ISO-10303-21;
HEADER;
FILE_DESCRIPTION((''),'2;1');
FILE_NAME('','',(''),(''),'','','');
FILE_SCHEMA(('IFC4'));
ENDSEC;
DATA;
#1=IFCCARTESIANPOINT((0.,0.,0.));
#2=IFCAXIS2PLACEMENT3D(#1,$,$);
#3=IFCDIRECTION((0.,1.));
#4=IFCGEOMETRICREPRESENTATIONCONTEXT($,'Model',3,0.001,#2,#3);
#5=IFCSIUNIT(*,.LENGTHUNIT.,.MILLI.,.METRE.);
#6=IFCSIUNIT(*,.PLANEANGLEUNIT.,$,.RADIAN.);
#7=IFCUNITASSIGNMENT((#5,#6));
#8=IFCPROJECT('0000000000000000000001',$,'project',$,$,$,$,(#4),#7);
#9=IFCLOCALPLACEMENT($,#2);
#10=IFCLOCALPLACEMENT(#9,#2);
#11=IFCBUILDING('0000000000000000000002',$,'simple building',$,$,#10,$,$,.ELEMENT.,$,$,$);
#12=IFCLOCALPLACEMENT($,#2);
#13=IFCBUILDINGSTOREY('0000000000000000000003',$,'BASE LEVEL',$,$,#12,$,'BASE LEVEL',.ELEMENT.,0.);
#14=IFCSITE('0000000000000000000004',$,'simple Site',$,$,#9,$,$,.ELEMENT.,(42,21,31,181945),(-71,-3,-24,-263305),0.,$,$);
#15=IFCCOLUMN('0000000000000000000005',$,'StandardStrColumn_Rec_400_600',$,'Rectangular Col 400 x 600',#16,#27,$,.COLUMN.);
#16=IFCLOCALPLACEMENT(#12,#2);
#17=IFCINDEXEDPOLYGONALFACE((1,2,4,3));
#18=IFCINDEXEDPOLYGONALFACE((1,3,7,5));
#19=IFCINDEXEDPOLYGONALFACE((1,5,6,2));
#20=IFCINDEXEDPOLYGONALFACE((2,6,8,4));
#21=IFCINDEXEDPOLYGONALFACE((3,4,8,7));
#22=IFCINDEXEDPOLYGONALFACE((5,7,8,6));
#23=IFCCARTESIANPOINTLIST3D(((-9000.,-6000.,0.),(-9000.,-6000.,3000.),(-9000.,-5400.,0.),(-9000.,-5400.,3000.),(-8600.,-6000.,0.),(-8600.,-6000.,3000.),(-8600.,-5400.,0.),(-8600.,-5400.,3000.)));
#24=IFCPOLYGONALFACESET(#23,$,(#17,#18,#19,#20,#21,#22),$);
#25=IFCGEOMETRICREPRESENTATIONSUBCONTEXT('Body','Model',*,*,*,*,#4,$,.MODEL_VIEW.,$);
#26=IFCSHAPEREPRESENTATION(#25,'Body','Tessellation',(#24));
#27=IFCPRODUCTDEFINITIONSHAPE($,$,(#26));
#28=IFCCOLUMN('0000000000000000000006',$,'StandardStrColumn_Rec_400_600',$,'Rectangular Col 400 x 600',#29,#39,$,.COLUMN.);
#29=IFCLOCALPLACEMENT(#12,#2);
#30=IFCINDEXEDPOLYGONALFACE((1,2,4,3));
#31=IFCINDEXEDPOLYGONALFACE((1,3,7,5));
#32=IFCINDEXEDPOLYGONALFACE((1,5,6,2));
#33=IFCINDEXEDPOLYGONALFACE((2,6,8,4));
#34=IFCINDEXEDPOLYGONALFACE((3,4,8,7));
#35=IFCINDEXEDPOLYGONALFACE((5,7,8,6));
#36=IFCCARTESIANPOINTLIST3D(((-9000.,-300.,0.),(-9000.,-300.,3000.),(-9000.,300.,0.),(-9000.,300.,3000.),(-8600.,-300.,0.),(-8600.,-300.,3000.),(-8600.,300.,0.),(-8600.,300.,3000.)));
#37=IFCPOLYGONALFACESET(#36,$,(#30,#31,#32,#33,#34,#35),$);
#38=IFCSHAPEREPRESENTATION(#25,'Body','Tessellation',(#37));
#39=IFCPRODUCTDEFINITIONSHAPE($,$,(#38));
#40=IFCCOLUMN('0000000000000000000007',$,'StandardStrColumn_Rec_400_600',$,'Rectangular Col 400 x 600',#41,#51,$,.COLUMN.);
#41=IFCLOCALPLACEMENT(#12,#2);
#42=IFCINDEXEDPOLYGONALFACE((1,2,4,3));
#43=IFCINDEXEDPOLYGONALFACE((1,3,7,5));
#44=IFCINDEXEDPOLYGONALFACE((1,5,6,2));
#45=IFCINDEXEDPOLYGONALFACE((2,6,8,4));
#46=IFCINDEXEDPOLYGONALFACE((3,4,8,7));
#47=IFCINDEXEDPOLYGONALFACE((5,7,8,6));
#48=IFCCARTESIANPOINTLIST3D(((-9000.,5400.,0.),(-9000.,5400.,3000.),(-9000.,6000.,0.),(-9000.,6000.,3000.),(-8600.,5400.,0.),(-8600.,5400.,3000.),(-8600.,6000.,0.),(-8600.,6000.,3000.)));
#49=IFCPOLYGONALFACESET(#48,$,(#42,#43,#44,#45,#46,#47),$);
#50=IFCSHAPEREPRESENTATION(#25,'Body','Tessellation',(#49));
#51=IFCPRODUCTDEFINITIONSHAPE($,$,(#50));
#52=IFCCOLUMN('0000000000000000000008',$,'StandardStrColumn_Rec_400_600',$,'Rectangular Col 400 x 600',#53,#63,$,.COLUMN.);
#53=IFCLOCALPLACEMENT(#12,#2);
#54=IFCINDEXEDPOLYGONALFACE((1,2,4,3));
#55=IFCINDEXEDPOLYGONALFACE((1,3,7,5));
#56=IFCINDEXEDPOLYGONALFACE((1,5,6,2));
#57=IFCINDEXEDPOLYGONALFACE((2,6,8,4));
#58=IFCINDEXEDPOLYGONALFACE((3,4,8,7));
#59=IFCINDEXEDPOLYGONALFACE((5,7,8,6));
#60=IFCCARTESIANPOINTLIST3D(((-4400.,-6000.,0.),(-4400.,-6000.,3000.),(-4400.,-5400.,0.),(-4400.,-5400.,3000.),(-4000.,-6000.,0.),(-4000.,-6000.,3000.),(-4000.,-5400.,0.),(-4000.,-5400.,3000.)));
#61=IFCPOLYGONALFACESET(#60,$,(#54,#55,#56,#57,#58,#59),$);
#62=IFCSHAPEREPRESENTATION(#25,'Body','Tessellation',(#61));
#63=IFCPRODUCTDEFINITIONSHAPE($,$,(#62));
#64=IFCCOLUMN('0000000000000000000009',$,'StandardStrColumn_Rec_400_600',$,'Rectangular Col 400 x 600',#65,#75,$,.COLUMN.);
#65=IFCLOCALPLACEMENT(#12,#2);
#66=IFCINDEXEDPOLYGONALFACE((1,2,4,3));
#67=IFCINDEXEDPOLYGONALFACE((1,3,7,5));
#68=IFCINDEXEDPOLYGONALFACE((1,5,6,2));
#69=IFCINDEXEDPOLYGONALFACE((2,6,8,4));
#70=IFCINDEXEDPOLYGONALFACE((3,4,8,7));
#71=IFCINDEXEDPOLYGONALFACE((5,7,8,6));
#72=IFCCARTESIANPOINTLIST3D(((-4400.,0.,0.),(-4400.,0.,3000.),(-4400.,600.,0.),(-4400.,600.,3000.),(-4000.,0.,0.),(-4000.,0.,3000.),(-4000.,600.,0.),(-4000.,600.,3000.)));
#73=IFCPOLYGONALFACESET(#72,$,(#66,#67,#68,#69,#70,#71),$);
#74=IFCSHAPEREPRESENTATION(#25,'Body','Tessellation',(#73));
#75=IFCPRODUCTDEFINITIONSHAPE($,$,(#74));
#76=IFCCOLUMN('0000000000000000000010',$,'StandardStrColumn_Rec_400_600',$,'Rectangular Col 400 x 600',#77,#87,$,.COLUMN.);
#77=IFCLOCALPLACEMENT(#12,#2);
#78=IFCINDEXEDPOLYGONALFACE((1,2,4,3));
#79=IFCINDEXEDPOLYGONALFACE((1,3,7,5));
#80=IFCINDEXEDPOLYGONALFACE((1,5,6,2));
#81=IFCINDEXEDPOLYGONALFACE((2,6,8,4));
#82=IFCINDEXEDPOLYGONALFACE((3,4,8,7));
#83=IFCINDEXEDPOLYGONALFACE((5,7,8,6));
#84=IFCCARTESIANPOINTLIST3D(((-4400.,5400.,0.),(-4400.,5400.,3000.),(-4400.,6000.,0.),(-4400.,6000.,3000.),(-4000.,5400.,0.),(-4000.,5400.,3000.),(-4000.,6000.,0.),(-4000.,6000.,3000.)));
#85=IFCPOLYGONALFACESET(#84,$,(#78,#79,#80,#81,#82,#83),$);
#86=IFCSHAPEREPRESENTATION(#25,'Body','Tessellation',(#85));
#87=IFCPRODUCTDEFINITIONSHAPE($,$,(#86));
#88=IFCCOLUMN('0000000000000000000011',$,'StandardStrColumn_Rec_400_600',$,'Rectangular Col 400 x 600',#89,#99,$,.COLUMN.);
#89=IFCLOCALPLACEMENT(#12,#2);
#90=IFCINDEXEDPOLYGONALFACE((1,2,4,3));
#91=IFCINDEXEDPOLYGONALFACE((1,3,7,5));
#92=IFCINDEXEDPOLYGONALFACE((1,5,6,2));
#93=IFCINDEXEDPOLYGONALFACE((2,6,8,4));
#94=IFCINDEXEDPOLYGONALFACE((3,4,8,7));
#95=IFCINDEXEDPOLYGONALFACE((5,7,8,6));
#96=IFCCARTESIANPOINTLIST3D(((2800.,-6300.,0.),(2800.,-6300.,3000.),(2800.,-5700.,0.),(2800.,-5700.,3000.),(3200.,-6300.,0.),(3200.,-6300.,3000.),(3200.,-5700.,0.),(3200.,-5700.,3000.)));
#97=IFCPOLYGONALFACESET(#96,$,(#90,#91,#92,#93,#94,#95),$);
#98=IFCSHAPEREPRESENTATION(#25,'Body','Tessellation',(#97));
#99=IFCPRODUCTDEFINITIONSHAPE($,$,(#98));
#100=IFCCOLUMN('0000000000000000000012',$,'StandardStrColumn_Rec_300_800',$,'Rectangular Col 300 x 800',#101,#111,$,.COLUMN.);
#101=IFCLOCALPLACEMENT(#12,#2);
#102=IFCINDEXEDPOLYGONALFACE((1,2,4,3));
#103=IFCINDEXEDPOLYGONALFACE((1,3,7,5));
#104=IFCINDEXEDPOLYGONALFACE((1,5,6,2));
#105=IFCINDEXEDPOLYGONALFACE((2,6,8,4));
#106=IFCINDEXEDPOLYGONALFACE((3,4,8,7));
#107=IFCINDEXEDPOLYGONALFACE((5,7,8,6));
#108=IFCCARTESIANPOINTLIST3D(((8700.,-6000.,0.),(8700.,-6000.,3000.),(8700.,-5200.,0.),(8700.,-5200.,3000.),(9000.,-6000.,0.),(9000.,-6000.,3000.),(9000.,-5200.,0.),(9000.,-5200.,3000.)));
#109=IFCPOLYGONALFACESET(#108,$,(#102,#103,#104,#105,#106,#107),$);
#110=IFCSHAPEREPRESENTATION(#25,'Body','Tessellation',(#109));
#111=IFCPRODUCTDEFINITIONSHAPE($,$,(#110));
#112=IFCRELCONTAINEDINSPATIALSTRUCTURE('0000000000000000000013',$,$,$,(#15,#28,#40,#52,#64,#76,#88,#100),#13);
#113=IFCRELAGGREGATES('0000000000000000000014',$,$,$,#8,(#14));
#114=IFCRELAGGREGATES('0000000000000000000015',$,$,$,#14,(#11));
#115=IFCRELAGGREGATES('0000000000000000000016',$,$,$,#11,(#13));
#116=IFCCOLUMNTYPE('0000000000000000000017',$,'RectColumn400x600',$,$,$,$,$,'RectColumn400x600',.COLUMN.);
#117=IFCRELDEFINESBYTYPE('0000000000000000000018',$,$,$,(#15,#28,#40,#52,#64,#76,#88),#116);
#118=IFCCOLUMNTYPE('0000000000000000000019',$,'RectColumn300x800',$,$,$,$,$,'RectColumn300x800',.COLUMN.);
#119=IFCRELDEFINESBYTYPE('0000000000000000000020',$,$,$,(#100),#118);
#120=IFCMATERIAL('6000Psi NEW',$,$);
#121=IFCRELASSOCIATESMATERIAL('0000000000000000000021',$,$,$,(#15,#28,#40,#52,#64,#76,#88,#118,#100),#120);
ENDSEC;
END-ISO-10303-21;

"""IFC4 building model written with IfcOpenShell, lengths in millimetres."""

from ifc_helpers import new_model, si_unit, direction, frame, origin, origin_with_axes, origin_2d_with_axis, place, context, subcontext, project, spatial, rectangle, extrude, material, material_profile, profile_set, profile_usage, type_object, element, save


model = new_model("IFC4")

# Units and contexts
model_context = context("Model", 3, precision=0.001, world=origin(), true_north=direction((0.0, 1.0)))
body_context = subcontext(model_context, "Body", "Model", "MODEL_VIEW")
ifc_project = project(units=[si_unit("LENGTHUNIT", "METRE", prefix="MILLI"), si_unit("PLANEANGLEUNIT", "RADIAN")], contexts=[model_context])

# Site, building, storey
site_placement = place(None, origin())
site = spatial("IfcSite", under=ifc_project, at=site_placement, Name="simple Site", CompositionType="ELEMENT", RefLatitude=(42, 21, 31, 181945), RefLongitude=(-71, -3, -24, -263305), RefElevation=0.0)
building_placement = place(site_placement, origin())
building = spatial("IfcBuilding", under=site, at=building_placement, Name="simple building", CompositionType="ELEMENT")
storey_placement = place(None, origin())
storey = spatial("IfcBuildingStorey", under=building, at=storey_placement, Name="BASE LEVEL", LongName="BASE LEVEL", CompositionType="ELEMENT", Elevation=0.0)

# Columns
ifc_material = material(Name="6000Psi NEW")
ifc_material_profile_1 = material_profile(ifc_material, rectangle(XDim=400.0, YDim=600.0, at=origin_2d_with_axis()))
ifc_profile_set_1 = profile_set([ifc_material_profile_1])
ifc_profile_usage_1 = profile_usage(ifc_profile_set_1, cardinal=7)
column_type_1 = type_object("IfcColumnType", Name="RectColumn400x600", ElementType="RectColumn400x600", PredefinedType="COLUMN")
column_1_placement = place(None, frame((-8800.0, -5700.0, 0.0), z_axis=(0.0, 0.0, 1.0), x_axis=(1.0, 0.0, 0.0)))
element("IfcColumn", 1, at=column_1_placement, inside=storey, type_object=column_type_1, material=ifc_profile_usage_1, Name="StandardStrColumn_Rec_400_600", ObjectType="Rectangular Col 400 x 600", PredefinedType="COLUMN", context=body_context, shape_type="SweptSolid", body=[
    extrude(rectangle(XDim=400.0, YDim=600.0, at=origin_2d_with_axis()), origin_with_axes(), (0.0, 0.0, 1.0), 3000.0),
])
ifc_profile_usage_2 = profile_usage(ifc_profile_set_1, cardinal=4)
column_2_placement = place(None, frame((-8800.0, 0.0, 0.0), z_axis=(0.0, 0.0, 1.0), x_axis=(1.0, 0.0, 0.0)))
element("IfcColumn", 2, at=column_2_placement, inside=storey, type_object=column_type_1, material=ifc_profile_usage_2, Name="StandardStrColumn_Rec_400_600", ObjectType="Rectangular Col 400 x 600", PredefinedType="COLUMN", context=body_context, shape_type="SweptSolid", body=[
    extrude(rectangle(XDim=400.0, YDim=600.0, at=origin_2d_with_axis()), origin_with_axes(), (0.0, 0.0, 1.0), 3000.0),
])
ifc_profile_usage_3 = profile_usage(ifc_profile_set_1, cardinal=1)
column_3_placement = place(None, frame((-8800.0, 5700.0, 0.0), z_axis=(0.0, 0.0, 1.0), x_axis=(1.0, 0.0, 0.0)))
element("IfcColumn", 3, at=column_3_placement, inside=storey, type_object=column_type_1, material=ifc_profile_usage_3, Name="StandardStrColumn_Rec_400_600", ObjectType="Rectangular Col 400 x 600", PredefinedType="COLUMN", context=body_context, shape_type="SweptSolid", body=[
    extrude(rectangle(XDim=400.0, YDim=600.0, at=origin_2d_with_axis()), origin_with_axes(), (0.0, 0.0, 1.0), 3000.0),
])
ifc_profile_usage_4 = profile_usage(ifc_profile_set_1, cardinal=9)
for number, where, z_axis, x_axis, name in (
    (4, (-4200.0, -5700.0, 0.0), (0.0, 0.0, 1.0), (1.0, 0.0, 0.0), "StandardStrColumn_Rec_400_600"),
    (5, (-4200.0, 300.0, 0.0), (0.0, 0.0, 1.0), (1.0, 0.0, 0.0), "StandardStrColumn_Rec_400_600"),
):
    element("IfcColumn", number, at=place(None, frame(where, z_axis=z_axis, x_axis=x_axis)), inside=storey, type_object=column_type_1, material=ifc_profile_usage_4, Name=name, ObjectType="Rectangular Col 400 x 600", PredefinedType="COLUMN", context=body_context, shape_type="SweptSolid", body=[
        extrude(rectangle(XDim=400.0, YDim=600.0, at=origin_2d_with_axis()), origin_with_axes(), (0.0, 0.0, 1.0), 3000.0),
    ])
ifc_profile_usage_5 = profile_usage(ifc_profile_set_1, cardinal=3)
column_4_placement = place(None, frame((-4200.0, 5700.0, 0.0), z_axis=(0.0, 0.0, 1.0), x_axis=(1.0, 0.0, 0.0)))
element("IfcColumn", 6, at=column_4_placement, inside=storey, type_object=column_type_1, material=ifc_profile_usage_5, Name="StandardStrColumn_Rec_400_600", ObjectType="Rectangular Col 400 x 600", PredefinedType="COLUMN", context=body_context, shape_type="SweptSolid", body=[
    extrude(rectangle(XDim=400.0, YDim=600.0, at=origin_2d_with_axis()), origin_with_axes(), (0.0, 0.0, 1.0), 3000.0),
])
ifc_profile_usage_6 = profile_usage(ifc_profile_set_1, cardinal=5)
column_5_placement = place(None, frame((3000.0, -6000.0, 0.0), z_axis=(0.0, 0.0, 1.0), x_axis=(1.0, 0.0, 0.0)))
element("IfcColumn", 7, at=column_5_placement, inside=storey, type_object=column_type_1, material=ifc_profile_usage_6, Name="StandardStrColumn_Rec_400_600", ObjectType="Rectangular Col 400 x 600", PredefinedType="COLUMN", context=body_context, shape_type="SweptSolid", body=[
    extrude(rectangle(XDim=400.0, YDim=600.0, at=origin_2d_with_axis()), origin_with_axes(), (0.0, 0.0, 1.0), 3000.0),
])
ifc_material_profile_2 = material_profile(ifc_material, rectangle(XDim=300.0, YDim=800.0, at=origin_2d_with_axis()))
ifc_profile_set_2 = profile_set([ifc_material_profile_2])
ifc_profile_usage_7 = profile_usage(ifc_profile_set_2, cardinal=9)
column_type_2 = type_object("IfcColumnType", Name="RectColumn300x800", ElementType="RectColumn300x800", PredefinedType="COLUMN", material=ifc_profile_usage_7)
column_6_placement = place(None, frame((8850.0, -5600.0, 0.0), z_axis=(0.0, 0.0, 1.0), x_axis=(1.0, 0.0, 0.0)))
element("IfcColumn", 8, at=column_6_placement, inside=storey, type_object=column_type_2, material=ifc_profile_usage_7, Name="StandardStrColumn_Rec_300_800", ObjectType="Rectangular Col 300 x 800", PredefinedType="COLUMN", context=body_context, shape_type="SweptSolid", body=[
    extrude(rectangle(XDim=300.0, YDim=800.0, at=origin_2d_with_axis()), origin_with_axes(), (0.0, 0.0, 1.0), 3000.0),
])

save(model, "model.ifc")
